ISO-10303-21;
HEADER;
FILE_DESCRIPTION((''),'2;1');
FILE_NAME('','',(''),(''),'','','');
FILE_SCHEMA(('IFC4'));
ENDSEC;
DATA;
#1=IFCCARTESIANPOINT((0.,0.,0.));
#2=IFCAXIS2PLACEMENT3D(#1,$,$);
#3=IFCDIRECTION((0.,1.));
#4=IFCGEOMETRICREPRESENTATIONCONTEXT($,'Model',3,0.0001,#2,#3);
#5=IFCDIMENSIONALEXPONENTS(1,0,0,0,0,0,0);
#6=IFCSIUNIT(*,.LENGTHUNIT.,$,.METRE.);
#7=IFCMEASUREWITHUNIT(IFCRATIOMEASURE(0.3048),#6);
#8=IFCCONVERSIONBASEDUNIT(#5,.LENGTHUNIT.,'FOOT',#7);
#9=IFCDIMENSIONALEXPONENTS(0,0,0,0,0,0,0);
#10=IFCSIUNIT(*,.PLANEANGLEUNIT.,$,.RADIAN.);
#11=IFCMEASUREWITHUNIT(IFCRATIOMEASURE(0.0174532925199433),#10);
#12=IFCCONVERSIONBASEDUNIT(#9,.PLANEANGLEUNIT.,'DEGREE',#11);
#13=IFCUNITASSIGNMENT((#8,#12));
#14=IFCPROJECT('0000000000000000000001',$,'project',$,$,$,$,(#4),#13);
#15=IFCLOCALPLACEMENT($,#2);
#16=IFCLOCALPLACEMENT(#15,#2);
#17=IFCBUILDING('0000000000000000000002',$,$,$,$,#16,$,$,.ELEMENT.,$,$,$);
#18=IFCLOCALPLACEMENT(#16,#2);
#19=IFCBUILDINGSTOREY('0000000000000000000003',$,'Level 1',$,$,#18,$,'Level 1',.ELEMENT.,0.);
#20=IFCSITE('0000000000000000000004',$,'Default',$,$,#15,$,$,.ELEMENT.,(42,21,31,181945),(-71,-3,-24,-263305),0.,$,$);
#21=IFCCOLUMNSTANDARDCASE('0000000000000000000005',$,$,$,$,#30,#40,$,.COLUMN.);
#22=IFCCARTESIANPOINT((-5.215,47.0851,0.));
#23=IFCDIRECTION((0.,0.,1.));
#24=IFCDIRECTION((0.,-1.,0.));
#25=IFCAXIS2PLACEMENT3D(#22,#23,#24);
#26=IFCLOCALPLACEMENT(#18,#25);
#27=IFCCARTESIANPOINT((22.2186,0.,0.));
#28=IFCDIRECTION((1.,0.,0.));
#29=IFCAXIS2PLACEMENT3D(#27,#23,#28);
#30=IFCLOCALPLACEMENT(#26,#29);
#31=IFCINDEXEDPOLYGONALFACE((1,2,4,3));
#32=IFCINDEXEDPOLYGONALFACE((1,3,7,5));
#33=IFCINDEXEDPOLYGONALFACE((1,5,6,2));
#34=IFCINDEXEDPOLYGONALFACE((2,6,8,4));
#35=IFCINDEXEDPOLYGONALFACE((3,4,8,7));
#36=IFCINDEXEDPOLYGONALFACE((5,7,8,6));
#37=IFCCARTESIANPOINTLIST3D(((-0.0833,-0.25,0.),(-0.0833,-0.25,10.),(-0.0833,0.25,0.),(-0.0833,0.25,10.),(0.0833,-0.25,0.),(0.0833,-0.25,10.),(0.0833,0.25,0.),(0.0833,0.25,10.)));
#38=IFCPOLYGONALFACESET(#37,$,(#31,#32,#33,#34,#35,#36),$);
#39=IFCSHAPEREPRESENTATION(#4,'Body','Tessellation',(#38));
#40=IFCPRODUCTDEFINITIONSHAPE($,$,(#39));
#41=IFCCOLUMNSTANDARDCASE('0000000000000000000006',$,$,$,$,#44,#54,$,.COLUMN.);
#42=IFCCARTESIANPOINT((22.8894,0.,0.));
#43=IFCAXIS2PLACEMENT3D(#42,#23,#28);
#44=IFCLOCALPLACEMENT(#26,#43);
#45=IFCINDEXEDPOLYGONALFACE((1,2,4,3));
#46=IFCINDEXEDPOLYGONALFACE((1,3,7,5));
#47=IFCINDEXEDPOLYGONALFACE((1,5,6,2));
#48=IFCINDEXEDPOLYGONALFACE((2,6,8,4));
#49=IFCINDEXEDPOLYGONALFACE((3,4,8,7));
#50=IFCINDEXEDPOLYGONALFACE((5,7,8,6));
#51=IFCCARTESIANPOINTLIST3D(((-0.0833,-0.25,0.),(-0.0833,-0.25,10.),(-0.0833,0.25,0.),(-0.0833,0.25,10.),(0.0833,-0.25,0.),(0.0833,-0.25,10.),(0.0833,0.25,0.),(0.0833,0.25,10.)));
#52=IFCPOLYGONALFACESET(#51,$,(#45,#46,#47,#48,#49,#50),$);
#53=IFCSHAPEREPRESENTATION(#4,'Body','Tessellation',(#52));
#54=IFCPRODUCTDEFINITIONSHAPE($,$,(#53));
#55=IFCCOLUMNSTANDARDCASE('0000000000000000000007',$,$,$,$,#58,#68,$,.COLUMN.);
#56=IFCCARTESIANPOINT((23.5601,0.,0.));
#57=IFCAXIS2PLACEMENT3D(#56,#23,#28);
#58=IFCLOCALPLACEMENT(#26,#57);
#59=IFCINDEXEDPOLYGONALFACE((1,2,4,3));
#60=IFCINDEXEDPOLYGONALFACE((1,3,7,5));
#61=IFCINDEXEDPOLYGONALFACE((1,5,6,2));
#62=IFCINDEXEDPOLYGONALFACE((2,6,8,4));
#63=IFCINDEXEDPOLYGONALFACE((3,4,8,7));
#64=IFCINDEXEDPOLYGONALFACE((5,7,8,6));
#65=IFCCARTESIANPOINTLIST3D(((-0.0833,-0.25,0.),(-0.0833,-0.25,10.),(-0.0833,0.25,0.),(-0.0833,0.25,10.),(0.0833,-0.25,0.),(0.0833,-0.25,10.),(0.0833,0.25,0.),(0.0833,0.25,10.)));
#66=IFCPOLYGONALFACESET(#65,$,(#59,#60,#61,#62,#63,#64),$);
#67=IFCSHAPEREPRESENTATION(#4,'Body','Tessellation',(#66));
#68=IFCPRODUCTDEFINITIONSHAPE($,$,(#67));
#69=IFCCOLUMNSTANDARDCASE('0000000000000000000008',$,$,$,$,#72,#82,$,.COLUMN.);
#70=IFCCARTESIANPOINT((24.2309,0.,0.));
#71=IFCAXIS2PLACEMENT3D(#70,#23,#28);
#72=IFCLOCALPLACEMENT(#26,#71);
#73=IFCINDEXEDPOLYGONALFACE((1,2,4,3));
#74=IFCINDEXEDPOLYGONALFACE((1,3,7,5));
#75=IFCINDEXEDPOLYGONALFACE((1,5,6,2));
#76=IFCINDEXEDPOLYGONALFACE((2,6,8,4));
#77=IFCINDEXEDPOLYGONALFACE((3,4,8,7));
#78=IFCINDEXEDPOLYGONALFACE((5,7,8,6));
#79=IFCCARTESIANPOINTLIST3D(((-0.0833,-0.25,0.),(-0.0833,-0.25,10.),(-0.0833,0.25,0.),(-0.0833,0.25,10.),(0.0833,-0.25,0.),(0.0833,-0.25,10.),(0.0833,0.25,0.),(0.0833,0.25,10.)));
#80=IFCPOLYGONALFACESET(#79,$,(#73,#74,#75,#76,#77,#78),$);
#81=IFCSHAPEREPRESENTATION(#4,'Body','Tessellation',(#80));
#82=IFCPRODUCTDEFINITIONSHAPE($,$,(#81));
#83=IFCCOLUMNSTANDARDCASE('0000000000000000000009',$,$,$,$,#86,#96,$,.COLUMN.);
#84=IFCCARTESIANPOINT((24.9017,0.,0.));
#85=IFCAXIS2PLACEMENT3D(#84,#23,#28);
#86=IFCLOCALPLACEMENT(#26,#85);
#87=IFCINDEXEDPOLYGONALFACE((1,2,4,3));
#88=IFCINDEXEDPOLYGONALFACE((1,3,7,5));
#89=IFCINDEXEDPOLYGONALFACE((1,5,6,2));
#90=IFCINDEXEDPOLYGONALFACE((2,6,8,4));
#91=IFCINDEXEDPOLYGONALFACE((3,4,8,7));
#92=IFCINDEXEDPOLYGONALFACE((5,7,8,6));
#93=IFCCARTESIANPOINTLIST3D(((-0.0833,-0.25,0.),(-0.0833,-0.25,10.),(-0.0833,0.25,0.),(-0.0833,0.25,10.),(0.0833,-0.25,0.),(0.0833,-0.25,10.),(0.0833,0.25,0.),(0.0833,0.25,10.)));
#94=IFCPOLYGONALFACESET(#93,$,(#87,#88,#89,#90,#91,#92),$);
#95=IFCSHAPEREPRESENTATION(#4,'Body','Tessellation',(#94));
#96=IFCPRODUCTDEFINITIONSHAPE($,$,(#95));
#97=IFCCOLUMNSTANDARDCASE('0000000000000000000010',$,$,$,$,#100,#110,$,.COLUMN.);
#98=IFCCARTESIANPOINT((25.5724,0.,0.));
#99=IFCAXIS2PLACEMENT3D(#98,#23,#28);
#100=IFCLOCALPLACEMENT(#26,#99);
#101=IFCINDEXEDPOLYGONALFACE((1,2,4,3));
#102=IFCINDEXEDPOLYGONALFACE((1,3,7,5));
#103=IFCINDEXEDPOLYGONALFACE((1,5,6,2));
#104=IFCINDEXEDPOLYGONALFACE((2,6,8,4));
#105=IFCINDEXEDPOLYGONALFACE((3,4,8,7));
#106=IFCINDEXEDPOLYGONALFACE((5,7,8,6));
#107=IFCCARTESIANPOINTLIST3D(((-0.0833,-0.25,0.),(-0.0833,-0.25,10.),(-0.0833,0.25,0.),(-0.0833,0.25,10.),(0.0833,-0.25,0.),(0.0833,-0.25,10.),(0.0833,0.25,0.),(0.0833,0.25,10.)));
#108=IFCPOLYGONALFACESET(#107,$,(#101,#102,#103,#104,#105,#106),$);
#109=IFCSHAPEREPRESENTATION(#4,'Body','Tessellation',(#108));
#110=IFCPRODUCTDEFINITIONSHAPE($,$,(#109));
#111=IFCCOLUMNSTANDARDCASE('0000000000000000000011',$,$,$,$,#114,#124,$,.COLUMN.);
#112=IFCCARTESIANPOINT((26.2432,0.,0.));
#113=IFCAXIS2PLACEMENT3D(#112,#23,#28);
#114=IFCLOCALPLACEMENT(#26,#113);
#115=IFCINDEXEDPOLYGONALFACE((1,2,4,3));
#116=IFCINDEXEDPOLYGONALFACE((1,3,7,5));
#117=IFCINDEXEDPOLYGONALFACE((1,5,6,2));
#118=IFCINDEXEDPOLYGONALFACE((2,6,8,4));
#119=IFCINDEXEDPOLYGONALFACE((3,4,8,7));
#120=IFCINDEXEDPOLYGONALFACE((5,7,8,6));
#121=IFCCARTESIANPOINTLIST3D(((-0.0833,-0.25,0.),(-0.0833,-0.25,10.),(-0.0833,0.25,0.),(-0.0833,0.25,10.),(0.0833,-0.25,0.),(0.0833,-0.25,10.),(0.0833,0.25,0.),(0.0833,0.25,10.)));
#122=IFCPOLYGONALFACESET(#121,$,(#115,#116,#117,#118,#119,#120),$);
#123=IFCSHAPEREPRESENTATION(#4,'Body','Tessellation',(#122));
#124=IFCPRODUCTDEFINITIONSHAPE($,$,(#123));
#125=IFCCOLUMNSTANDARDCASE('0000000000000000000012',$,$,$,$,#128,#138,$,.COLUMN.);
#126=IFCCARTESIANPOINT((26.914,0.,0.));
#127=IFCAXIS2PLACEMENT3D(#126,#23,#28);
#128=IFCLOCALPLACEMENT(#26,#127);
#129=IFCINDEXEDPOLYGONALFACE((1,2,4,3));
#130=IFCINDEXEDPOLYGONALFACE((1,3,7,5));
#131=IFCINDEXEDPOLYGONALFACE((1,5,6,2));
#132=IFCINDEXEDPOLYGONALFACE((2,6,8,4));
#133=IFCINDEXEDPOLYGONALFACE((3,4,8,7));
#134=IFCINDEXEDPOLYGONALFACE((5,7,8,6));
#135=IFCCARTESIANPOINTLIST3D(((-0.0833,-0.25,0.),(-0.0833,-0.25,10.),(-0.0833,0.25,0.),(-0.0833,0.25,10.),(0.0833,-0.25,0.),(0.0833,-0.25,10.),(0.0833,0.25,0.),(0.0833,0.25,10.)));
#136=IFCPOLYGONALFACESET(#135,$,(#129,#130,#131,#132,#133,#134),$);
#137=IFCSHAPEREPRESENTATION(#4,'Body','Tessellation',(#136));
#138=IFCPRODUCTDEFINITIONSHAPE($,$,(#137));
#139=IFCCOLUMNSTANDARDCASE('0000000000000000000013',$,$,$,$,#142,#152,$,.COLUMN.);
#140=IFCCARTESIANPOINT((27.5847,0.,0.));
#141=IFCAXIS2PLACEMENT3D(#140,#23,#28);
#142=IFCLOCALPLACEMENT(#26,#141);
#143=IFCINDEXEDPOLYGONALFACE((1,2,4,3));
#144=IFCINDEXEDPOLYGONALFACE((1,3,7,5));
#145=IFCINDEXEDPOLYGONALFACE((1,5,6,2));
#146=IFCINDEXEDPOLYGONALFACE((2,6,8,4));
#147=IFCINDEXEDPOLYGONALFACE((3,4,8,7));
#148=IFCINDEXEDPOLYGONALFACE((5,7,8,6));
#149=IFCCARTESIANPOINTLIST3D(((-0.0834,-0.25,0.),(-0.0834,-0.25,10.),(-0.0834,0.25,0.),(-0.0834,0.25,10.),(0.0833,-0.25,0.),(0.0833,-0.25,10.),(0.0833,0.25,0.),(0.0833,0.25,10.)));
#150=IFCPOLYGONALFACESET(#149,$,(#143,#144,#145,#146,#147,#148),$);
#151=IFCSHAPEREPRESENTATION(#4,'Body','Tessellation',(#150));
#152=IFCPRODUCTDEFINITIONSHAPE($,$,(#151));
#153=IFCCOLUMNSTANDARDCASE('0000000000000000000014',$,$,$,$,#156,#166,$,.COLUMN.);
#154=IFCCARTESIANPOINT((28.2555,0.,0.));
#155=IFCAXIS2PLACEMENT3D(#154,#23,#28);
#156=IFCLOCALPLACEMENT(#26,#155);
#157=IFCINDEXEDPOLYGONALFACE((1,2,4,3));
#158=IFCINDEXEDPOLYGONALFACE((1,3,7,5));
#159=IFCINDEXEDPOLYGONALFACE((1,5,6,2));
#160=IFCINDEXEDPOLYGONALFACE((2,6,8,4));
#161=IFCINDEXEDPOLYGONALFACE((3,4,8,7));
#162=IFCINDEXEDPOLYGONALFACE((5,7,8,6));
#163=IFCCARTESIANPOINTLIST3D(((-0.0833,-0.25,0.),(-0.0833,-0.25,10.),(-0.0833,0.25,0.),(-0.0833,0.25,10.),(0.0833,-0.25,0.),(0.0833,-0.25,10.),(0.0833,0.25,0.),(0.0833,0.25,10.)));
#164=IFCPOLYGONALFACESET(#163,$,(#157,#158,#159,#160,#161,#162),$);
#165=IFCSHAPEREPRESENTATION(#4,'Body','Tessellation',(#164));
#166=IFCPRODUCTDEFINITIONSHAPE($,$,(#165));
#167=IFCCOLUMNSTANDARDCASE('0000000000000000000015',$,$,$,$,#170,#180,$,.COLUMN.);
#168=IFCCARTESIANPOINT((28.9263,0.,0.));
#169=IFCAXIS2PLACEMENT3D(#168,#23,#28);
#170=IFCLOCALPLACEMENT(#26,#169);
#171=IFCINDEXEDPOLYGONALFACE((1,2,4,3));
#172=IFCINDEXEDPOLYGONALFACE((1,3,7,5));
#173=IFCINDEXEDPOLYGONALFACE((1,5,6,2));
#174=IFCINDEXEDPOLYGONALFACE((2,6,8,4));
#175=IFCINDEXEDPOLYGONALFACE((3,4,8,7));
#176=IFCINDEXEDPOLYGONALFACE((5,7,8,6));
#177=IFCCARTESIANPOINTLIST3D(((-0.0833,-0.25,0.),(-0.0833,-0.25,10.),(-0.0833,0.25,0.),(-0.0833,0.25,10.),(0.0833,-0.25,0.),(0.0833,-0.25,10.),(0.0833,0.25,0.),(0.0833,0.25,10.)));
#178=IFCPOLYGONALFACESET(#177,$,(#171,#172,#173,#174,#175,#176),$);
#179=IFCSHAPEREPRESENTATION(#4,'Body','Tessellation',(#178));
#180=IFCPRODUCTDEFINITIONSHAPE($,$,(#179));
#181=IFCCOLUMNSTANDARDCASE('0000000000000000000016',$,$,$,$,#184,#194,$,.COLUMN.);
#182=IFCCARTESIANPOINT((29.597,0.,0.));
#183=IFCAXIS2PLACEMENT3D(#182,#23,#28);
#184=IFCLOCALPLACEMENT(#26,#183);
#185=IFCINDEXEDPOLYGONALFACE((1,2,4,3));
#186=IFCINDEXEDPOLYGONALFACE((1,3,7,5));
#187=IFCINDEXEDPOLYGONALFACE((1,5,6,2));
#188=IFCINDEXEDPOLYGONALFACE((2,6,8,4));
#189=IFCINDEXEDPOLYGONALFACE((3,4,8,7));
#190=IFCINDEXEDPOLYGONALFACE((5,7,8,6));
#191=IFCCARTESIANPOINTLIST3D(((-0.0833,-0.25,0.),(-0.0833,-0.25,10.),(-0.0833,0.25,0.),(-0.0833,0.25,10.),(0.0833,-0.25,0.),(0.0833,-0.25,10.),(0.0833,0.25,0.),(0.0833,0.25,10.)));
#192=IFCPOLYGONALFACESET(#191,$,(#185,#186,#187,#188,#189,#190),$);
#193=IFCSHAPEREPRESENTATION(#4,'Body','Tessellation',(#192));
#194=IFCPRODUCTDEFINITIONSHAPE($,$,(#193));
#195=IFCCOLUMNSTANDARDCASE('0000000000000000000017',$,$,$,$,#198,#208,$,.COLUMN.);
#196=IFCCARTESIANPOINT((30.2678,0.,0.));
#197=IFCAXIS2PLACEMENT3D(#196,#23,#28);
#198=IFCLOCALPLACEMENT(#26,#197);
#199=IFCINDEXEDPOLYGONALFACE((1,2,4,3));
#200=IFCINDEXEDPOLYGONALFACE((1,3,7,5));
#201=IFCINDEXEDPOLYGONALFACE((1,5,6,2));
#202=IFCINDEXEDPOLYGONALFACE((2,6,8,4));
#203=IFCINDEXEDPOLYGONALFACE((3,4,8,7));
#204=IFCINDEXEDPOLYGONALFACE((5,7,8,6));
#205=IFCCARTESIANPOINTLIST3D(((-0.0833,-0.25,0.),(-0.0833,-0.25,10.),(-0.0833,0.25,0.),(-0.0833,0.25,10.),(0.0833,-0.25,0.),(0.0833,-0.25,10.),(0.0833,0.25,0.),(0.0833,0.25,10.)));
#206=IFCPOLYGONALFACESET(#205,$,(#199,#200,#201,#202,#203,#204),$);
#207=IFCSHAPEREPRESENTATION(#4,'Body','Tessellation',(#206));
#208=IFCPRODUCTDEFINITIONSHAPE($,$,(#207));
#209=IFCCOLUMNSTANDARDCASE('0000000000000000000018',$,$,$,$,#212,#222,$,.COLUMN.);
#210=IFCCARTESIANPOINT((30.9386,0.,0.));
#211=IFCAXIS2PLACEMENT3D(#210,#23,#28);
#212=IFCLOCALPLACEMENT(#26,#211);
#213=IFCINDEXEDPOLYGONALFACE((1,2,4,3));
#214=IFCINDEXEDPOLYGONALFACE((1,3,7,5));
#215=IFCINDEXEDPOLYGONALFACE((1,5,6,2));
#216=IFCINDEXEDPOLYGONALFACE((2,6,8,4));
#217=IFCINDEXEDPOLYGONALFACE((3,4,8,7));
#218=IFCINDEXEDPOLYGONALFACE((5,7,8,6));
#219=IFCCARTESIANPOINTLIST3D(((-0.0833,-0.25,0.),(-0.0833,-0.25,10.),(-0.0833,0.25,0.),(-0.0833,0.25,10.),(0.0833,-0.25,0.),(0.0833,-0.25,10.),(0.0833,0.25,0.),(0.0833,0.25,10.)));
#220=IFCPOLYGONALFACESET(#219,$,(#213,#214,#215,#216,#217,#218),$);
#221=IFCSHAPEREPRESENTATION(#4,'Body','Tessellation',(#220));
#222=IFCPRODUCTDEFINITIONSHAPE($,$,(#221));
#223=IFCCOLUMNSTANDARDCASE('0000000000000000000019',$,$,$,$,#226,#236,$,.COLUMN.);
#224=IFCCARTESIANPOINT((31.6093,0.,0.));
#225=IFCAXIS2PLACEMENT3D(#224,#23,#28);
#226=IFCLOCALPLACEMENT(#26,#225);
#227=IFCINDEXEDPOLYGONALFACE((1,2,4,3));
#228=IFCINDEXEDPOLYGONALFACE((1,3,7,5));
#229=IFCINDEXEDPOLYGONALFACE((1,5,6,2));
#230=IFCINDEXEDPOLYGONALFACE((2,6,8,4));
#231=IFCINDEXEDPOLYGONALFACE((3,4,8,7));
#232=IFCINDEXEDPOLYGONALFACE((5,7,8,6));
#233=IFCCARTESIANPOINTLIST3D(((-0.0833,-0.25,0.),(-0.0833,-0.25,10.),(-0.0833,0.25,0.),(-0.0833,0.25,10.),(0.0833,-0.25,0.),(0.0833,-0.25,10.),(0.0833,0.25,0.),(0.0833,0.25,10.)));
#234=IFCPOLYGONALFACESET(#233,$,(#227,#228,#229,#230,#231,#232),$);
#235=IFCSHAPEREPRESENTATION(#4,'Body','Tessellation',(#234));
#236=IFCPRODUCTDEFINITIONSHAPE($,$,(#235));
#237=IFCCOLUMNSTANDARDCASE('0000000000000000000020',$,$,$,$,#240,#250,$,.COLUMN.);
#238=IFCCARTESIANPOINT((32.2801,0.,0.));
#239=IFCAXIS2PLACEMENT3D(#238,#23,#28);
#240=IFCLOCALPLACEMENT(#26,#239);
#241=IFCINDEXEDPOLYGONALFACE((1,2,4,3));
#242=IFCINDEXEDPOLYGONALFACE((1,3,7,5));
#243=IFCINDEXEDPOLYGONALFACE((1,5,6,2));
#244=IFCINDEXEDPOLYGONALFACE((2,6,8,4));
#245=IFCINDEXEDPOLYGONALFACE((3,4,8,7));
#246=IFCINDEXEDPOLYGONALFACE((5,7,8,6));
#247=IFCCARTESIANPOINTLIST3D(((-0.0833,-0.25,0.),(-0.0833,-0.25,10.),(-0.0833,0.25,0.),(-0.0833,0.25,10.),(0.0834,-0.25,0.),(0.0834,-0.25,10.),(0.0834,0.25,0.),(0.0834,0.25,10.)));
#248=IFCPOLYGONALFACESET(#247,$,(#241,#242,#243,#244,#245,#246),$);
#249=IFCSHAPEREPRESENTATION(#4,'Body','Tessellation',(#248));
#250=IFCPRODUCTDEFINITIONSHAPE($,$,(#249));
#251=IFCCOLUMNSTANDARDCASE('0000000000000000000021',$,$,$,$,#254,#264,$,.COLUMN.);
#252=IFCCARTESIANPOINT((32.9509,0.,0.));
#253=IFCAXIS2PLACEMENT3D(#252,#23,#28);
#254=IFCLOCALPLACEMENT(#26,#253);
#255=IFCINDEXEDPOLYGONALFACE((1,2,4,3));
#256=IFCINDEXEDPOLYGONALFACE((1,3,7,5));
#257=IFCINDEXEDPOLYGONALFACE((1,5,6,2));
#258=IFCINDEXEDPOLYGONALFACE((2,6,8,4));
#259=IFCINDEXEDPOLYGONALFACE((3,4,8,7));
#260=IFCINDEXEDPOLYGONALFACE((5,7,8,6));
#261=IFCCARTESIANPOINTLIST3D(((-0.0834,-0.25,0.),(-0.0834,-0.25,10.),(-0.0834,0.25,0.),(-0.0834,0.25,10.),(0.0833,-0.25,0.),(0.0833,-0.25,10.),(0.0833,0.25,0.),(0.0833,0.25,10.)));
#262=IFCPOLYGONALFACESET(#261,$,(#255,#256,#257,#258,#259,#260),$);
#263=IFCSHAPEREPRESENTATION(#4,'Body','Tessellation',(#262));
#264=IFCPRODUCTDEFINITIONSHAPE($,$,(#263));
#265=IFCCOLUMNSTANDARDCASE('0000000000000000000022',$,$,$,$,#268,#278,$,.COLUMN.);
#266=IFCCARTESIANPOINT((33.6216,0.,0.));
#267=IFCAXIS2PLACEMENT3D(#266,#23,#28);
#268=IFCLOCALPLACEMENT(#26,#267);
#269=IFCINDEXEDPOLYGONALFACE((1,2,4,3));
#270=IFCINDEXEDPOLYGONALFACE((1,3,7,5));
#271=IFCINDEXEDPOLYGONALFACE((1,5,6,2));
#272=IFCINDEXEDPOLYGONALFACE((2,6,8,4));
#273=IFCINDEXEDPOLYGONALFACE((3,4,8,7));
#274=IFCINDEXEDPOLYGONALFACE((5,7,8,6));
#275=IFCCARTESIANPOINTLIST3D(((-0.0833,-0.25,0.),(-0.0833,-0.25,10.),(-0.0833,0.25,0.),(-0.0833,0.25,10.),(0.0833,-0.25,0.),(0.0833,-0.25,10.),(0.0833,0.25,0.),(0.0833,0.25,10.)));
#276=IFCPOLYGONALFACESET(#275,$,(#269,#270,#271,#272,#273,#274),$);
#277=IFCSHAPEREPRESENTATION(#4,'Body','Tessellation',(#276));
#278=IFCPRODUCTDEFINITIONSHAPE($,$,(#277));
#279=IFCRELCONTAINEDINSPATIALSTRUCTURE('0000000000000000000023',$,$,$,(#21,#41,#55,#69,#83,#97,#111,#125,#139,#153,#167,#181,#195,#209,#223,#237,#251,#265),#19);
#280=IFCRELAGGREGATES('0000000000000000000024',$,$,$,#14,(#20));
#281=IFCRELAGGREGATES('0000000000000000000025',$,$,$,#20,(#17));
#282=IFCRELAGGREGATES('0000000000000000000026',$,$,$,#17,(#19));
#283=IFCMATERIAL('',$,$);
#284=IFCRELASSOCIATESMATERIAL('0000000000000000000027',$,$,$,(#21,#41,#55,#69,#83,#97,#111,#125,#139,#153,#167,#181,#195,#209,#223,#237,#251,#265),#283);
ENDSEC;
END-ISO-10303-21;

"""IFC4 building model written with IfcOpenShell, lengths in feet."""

from ifc_helpers import new_model, entity, si_unit, converted_unit, direction, frame, origin, place, context, project, spatial, rectangle, extrude, material, element, save


model = new_model("IFC4")

# Units and contexts
model_context = context("Model", 3, precision=0.0001, world=origin(), true_north=direction((0.0, 1.0)))
ifc_project = project(units=[converted_unit("LENGTHUNIT", "FOOT", entity("IfcRatioMeasure", 0.3048), si_unit("LENGTHUNIT", "METRE"), dimensions=[1, 0, 0, 0, 0, 0, 0]), converted_unit("PLANEANGLEUNIT", "DEGREE", entity("IfcRatioMeasure", 0.0174532925199433), si_unit("PLANEANGLEUNIT", "RADIAN"), dimensions=[0, 0, 0, 0, 0, 0, 0])], contexts=[model_context])

# Site, building, storey
site_placement = place(None, origin())
site = spatial("IfcSite", under=ifc_project, at=site_placement, Name="Default", CompositionType="ELEMENT", RefLatitude=(42, 21, 31, 181945), RefLongitude=(-71, -3, -24, -263305), RefElevation=0.0)
building_placement = place(site_placement, origin())
building = spatial("IfcBuilding", under=site, at=building_placement, CompositionType="ELEMENT")
storey_placement = place(building_placement, origin())
storey = spatial("IfcBuildingStorey", under=building, at=storey_placement, Name="Level 1", LongName="Level 1", CompositionType="ELEMENT", Elevation=0.0)

# Columns
ifc_material = material(Name="")
placement = place(storey_placement, frame((-5.215, 47.0851, 0.0), z_axis=(0.0, 0.0, 1.0), x_axis=(0.0, -1.0, 0.0)))
for number, where, z_axis, x_axis in (
    (1, (22.2186, 0.0, 0.0), (0.0, 0.0, 1.0), (1.0, 0.0, 0.0)),
    (2, (22.8894, 0.0, 0.0), (0.0, 0.0, 1.0), (1.0, 0.0, 0.0)),
    (3, (23.5601, 0.0, 0.0), (0.0, 0.0, 1.0), (1.0, 0.0, 0.0)),
    (4, (24.2309, 0.0, 0.0), (0.0, 0.0, 1.0), (1.0, 0.0, 0.0)),
    (5, (24.9017, 0.0, 0.0), (0.0, 0.0, 1.0), (1.0, 0.0, 0.0)),
    (6, (25.5724, 0.0, 0.0), (0.0, 0.0, 1.0), (1.0, 0.0, 0.0)),
    (7, (26.2432, 0.0, 0.0), (0.0, 0.0, 1.0), (1.0, 0.0, 0.0)),
    (8, (26.914, 0.0, 0.0), (0.0, 0.0, 1.0), (1.0, 0.0, 0.0)),
    (9, (27.5847, 0.0, 0.0), (0.0, 0.0, 1.0), (1.0, 0.0, 0.0)),
    (10, (28.2555, 0.0, 0.0), (0.0, 0.0, 1.0), (1.0, 0.0, 0.0)),
    (11, (28.9263, 0.0, 0.0), (0.0, 0.0, 1.0), (1.0, 0.0, 0.0)),
    (12, (29.597, 0.0, 0.0), (0.0, 0.0, 1.0), (1.0, 0.0, 0.0)),
    (13, (30.2678, 0.0, 0.0), (0.0, 0.0, 1.0), (1.0, 0.0, 0.0)),
    (14, (30.9386, 0.0, 0.0), (0.0, 0.0, 1.0), (1.0, 0.0, 0.0)),
    (15, (31.6093, 0.0, 0.0), (0.0, 0.0, 1.0), (1.0, 0.0, 0.0)),
    (16, (32.2801, 0.0, 0.0), (0.0, 0.0, 1.0), (1.0, 0.0, 0.0)),
    (17, (32.9509, 0.0, 0.0), (0.0, 0.0, 1.0), (1.0, 0.0, 0.0)),
    (18, (33.6216, 0.0, 0.0), (0.0, 0.0, 1.0), (1.0, 0.0, 0.0)),
):
    element("IfcColumnStandardCase", number, at=place(placement, frame(where, z_axis=z_axis, x_axis=x_axis)), inside=storey, material=ifc_material, PredefinedType="COLUMN", context=model_context, shape_type="SweptSolid", body=[
        extrude(rectangle(XDim=0.1667, YDim=0.5), origin(), (0.0, 0.0, 1.0), 10.0),
    ])

save(model, "model.ifc")
